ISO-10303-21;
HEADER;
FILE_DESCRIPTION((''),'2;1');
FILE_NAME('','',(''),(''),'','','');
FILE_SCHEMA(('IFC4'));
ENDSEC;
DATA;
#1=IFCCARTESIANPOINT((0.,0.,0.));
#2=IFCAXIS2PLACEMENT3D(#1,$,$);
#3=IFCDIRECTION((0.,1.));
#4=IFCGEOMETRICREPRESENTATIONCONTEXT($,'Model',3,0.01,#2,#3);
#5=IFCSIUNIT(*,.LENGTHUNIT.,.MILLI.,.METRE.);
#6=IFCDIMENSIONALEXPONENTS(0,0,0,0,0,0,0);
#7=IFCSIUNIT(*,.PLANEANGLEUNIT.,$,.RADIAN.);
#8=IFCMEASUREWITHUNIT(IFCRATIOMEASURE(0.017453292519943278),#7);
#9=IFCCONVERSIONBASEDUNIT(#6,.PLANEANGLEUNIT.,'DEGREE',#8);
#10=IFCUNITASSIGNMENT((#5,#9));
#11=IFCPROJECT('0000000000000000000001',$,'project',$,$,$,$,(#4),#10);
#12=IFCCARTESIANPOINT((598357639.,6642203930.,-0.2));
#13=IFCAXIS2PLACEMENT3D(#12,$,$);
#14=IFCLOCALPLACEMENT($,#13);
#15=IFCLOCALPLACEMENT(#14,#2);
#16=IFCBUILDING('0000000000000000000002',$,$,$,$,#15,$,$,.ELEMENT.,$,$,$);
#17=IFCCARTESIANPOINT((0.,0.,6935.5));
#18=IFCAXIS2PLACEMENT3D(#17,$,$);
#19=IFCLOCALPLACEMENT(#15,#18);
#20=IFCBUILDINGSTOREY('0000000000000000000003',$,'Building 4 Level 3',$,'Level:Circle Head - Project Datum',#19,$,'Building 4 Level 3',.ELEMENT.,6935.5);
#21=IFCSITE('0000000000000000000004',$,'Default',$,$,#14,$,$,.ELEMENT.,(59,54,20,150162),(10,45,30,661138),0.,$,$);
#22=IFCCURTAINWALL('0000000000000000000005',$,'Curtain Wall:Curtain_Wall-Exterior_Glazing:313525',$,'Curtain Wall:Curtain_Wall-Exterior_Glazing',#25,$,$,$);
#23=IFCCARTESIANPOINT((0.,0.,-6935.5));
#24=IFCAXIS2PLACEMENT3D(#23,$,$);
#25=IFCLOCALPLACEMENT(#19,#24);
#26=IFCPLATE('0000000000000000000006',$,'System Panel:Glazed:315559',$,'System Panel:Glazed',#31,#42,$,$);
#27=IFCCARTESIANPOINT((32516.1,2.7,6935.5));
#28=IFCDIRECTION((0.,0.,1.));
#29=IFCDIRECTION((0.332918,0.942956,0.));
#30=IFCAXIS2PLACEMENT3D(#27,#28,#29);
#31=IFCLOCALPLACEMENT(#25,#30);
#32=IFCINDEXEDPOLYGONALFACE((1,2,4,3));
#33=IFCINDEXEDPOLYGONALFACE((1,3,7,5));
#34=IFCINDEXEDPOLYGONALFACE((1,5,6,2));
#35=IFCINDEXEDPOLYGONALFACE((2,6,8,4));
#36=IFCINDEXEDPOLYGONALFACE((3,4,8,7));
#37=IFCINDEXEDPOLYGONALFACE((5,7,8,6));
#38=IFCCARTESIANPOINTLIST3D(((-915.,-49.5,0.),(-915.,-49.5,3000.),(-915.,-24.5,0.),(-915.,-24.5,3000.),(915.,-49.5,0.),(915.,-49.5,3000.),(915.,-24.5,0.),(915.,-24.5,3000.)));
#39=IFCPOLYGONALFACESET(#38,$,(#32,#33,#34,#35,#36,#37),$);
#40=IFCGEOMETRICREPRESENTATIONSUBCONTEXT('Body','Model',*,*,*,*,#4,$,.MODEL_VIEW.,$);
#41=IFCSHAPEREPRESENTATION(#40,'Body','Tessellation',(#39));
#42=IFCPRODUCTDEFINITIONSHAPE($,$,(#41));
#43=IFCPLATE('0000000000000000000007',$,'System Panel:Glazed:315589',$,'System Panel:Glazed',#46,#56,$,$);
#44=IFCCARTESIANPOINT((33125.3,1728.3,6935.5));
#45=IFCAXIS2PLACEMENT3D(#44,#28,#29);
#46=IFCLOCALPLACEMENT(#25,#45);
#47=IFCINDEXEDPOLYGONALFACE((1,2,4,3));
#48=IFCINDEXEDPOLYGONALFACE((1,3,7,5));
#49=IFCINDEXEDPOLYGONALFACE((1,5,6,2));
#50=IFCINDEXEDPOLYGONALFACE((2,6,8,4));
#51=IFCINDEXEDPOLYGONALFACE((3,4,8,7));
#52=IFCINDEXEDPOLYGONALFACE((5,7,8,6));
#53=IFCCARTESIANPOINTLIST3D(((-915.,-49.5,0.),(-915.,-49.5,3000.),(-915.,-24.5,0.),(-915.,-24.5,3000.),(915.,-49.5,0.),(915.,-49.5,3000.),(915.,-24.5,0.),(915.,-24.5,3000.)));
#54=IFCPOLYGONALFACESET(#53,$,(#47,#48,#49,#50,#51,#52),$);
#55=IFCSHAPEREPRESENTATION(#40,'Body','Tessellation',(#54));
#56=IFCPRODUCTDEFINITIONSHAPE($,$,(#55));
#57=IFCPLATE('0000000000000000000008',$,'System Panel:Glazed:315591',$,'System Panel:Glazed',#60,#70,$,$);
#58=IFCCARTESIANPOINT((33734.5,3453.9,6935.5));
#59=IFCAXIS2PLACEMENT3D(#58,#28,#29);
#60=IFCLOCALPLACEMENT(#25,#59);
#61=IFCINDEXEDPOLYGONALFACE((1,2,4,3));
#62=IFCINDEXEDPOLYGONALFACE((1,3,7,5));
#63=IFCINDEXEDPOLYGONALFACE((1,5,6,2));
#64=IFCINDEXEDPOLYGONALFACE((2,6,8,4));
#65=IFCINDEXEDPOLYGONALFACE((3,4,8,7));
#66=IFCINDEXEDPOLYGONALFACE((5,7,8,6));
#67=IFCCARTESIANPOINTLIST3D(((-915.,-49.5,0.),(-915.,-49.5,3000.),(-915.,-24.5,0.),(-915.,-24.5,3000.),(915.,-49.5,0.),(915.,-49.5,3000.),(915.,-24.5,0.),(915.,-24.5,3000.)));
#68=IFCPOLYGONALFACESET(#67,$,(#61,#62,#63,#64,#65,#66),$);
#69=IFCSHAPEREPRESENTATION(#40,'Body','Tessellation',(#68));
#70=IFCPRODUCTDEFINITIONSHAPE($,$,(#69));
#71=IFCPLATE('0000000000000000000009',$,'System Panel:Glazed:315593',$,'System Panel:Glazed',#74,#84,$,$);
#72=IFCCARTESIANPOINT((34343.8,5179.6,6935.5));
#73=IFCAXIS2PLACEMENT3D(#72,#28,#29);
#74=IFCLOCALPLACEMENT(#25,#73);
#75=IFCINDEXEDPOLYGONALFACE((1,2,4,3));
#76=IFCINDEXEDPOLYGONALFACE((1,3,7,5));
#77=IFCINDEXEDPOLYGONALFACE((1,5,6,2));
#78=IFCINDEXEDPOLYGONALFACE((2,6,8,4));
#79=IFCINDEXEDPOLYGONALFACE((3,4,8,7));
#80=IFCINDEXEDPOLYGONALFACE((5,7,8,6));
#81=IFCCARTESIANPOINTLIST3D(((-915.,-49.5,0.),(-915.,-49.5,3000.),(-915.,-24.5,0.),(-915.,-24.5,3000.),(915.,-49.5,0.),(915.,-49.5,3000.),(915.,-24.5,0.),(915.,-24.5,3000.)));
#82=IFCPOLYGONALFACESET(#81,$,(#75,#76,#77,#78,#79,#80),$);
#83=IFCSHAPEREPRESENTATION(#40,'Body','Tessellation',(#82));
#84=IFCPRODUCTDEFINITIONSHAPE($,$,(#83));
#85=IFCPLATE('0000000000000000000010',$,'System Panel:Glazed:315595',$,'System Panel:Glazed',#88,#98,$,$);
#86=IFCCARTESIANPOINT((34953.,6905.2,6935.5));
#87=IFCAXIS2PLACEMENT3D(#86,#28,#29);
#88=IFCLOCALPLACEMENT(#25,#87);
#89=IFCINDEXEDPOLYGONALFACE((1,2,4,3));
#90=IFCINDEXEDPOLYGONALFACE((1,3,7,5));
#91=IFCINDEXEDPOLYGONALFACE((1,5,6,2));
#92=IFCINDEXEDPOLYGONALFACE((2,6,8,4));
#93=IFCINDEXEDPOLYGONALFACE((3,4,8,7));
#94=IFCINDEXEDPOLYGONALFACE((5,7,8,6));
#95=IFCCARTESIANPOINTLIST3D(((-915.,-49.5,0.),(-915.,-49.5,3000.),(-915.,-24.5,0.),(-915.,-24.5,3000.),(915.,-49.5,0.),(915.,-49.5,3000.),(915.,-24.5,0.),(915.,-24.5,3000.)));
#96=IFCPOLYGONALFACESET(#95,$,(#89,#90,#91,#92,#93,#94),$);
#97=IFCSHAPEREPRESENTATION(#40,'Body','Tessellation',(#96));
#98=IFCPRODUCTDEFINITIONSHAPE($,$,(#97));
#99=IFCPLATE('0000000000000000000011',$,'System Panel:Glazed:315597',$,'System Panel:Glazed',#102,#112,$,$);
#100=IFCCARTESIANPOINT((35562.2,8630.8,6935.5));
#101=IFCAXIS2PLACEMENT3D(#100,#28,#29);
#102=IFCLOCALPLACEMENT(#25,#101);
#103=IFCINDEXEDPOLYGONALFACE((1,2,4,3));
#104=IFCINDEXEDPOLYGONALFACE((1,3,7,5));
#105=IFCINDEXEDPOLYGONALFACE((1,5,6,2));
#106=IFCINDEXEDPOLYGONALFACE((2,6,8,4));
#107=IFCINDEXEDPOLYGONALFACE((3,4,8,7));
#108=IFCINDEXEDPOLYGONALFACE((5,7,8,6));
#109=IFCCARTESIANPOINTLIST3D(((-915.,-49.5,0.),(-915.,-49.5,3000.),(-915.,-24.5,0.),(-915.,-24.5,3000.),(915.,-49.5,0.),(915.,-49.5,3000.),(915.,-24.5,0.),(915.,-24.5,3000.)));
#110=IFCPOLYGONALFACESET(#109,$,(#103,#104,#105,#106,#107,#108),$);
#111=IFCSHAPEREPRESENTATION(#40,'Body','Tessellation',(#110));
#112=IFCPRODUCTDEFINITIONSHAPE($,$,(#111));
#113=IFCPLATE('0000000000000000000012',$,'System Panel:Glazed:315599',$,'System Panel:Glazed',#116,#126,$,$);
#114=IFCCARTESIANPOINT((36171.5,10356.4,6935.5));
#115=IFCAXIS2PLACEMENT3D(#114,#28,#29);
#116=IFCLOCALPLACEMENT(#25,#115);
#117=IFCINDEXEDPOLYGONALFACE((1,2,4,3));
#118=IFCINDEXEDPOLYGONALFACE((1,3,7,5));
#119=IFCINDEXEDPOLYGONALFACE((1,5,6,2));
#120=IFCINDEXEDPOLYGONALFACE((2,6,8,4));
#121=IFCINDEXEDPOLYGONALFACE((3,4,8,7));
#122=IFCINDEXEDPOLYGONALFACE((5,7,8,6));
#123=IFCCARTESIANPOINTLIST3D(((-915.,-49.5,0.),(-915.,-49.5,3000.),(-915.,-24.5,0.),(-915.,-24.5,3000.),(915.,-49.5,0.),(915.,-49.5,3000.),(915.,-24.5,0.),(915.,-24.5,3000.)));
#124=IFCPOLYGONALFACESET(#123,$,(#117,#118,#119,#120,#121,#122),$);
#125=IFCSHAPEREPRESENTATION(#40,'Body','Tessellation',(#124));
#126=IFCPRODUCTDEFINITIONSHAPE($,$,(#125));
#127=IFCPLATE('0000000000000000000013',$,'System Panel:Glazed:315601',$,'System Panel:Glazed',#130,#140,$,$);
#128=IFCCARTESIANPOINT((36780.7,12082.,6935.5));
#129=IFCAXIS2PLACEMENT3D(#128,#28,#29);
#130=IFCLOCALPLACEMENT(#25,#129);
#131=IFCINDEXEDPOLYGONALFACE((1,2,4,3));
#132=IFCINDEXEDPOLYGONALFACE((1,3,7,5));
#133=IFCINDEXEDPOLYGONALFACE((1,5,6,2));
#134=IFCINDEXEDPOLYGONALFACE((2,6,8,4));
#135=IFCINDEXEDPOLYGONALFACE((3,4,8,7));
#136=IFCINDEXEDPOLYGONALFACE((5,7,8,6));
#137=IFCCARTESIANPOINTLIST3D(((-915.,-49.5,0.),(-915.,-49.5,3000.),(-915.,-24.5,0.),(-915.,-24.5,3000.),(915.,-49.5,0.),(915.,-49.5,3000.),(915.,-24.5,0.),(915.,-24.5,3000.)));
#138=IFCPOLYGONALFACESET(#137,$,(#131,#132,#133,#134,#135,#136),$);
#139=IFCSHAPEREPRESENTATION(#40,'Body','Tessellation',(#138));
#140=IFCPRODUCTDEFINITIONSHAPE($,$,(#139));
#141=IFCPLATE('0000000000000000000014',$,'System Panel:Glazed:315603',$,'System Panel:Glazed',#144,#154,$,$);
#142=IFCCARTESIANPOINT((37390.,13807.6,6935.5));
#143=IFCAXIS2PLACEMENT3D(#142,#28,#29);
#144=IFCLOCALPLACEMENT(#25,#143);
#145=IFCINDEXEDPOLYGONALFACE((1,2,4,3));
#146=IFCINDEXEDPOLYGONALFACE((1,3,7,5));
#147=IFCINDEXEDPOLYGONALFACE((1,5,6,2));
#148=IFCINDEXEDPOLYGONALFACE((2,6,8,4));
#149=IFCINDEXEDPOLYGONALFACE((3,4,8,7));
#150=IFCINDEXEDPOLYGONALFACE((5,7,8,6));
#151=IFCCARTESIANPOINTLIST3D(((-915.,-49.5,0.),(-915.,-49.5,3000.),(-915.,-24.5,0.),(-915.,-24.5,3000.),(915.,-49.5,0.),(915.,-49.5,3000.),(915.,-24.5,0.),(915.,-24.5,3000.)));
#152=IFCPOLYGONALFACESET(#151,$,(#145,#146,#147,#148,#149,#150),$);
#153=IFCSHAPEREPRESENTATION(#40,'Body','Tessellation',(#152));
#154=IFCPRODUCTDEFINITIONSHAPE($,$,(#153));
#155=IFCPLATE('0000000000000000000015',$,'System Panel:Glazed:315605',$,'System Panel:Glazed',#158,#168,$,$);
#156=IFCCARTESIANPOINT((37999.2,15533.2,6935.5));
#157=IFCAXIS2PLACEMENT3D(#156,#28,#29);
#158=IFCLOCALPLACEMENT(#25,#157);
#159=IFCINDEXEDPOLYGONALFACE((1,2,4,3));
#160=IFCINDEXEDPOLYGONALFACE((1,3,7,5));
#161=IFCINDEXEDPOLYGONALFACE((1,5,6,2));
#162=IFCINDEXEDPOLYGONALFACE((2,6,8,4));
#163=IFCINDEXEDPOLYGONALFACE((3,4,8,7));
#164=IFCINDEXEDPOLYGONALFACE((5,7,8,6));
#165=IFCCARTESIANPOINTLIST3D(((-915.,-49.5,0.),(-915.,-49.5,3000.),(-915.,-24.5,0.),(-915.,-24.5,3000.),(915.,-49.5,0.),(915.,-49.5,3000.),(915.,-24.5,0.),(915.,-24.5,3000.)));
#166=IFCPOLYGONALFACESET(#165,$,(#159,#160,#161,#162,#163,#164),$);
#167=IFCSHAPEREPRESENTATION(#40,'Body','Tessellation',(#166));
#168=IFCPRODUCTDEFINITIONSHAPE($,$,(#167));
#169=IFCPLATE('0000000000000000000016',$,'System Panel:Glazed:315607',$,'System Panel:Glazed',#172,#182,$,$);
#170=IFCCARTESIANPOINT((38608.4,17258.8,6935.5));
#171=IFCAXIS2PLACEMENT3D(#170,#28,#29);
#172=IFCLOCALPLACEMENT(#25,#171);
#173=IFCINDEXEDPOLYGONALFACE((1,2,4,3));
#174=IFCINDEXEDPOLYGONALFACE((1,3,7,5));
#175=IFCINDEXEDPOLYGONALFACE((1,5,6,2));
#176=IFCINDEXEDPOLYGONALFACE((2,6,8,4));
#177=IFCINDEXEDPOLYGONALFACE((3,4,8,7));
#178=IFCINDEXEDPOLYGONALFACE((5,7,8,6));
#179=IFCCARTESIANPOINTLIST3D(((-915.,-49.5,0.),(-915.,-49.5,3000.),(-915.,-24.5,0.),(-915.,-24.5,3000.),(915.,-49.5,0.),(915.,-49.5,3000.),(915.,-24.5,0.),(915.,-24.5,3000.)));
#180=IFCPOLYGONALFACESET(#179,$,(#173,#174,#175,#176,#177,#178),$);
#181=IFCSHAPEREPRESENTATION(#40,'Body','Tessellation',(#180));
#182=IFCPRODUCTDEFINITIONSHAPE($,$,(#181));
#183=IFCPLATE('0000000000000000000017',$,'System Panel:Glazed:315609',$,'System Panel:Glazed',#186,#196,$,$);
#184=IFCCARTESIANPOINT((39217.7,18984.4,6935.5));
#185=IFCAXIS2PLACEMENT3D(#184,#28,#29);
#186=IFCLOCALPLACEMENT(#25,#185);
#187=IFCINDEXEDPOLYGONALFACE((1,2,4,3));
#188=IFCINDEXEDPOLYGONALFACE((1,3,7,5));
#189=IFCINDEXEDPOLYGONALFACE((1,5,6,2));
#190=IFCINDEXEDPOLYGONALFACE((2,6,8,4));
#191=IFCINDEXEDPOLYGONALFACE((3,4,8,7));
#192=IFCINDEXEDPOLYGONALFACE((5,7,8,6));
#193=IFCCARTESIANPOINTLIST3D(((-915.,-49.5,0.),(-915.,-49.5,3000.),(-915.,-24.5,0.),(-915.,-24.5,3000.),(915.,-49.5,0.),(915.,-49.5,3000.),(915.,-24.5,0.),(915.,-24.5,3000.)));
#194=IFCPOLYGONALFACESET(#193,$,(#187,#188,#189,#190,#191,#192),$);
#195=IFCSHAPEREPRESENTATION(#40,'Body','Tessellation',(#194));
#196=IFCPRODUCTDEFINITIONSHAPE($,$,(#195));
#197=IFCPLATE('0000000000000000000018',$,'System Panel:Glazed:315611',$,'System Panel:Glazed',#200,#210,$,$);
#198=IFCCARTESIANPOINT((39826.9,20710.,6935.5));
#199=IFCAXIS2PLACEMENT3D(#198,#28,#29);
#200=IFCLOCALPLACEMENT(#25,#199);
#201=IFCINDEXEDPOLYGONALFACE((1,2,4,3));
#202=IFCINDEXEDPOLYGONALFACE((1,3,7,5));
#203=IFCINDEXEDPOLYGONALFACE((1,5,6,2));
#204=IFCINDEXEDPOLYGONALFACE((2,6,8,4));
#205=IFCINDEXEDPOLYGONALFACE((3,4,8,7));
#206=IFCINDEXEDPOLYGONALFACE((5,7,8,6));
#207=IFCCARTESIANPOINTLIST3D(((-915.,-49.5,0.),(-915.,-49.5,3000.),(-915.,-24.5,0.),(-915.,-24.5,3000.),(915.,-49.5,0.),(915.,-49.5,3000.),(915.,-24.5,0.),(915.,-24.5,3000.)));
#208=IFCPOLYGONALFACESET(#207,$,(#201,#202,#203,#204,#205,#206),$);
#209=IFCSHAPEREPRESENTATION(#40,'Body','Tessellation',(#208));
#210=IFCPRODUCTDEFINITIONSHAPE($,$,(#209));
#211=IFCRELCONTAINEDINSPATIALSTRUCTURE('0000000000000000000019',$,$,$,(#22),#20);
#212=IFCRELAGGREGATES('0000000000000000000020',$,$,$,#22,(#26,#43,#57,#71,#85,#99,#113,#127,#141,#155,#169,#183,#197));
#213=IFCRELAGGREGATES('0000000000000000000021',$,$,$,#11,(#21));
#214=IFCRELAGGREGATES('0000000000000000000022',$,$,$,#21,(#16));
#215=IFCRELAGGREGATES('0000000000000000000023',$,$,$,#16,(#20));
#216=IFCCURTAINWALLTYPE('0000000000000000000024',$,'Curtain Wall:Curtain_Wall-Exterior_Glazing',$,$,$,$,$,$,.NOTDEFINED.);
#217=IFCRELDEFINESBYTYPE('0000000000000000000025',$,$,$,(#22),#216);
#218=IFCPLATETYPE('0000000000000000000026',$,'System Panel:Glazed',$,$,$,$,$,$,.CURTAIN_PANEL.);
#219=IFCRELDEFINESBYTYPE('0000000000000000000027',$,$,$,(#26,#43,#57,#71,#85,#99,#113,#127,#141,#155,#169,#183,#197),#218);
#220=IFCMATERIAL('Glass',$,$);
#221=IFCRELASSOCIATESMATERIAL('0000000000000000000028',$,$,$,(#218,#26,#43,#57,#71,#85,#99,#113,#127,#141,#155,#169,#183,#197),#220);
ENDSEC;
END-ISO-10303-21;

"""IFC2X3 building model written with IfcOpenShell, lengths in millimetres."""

from ifc_helpers import new_model, entity, si_unit, converted_unit, direction, frame, frame_2d, origin, place, context, subcontext, project, spatial, rectangle, extrude, source, transform, mapped, material, type_object, type_shapes, element, aggregate, save


model = new_model("IFC2X3")

# Units and contexts
model_context = context("Model", 3, precision=0.01, world=origin(), true_north=direction((0.0, 1.0)))
body_context = subcontext(model_context, "Body", "Model", "MODEL_VIEW")
ifc_project = project(units=[si_unit("LENGTHUNIT", "METRE", prefix="MILLI"), converted_unit("PLANEANGLEUNIT", "DEGREE", entity("IfcRatioMeasure", 0.017453292519943278), si_unit("PLANEANGLEUNIT", "RADIAN"), dimensions=[0, 0, 0, 0, 0, 0, 0])], contexts=[model_context])

# Site, building, storey
site_placement = place(None, frame((598357639.0, 6642203930.0, -0.2)))
site = spatial("IfcSite", under=ifc_project, at=site_placement, Name="Default", CompositionType="ELEMENT", RefLatitude=(59, 54, 20, 150162), RefLongitude=(10, 45, 30, 661138), RefElevation=0.0)
building_placement = place(site_placement, origin())
building = spatial("IfcBuilding", under=site, at=building_placement, CompositionType="ELEMENT")
storey_placement = place(building_placement, frame((0.0, 0.0, 6935.5)))
storey = spatial("IfcBuildingStorey", under=building, at=storey_placement, Name="Building 4 Level 3", ObjectType="Level:Circle Head - Project Datum", LongName="Building 4 Level 3", CompositionType="ELEMENT", Elevation=6935.5)

# Curtain wall, plates
curtain_wall_type = type_object("IfcCurtainWallType", Name="Curtain Wall:Curtain_Wall-Exterior_Glazing", PredefinedType="NOTDEFINED")
curtain_wall_placement = place(storey_placement, frame((0.0, 0.0, -6935.5)))
curtain_wall = element("IfcCurtainWall", 1, at=curtain_wall_placement, inside=storey, type_object=curtain_wall_type, Name="Curtain Wall:Curtain_Wall-Exterior_Glazing:313525", ObjectType="Curtain Wall:Curtain_Wall-Exterior_Glazing")
ifc_material_1 = material(Name="Glass")
plate_type_1 = type_object("IfcPlateType", Name="System Panel:Glazed", PredefinedType="CURTAIN_PANEL", material=ifc_material_1)
shared_shape_1 = source(origin(), body_context, "Body", "SweptSolid", [
    extrude(rectangle(XDim=25.0, YDim=1830.0, at=frame_2d((0.0, 0.0), x_axis=(1.0, 0.0))), frame((0.0, -37.0, 0.0), z_axis=(0.0, 0.0, 1.0), x_axis=(0.0, 1.0, 0.0)), (0.0, 0.0, 1.0), 3000.0),
])
type_shapes(plate_type_1, [shared_shape_1])
plate_1_placement = place(curtain_wall_placement, frame((32516.1, 2.7, 6935.5), z_axis=(0.0, 0.0, 1.0), x_axis=(0.332918, 0.942956, 0.0)))
plate_1 = element("IfcPlate", 2, at=plate_1_placement, type_object=plate_type_1, material=ifc_material_1, Name="System Panel:Glazed:315559", ObjectType="System Panel:Glazed", context=body_context, shape_type="MappedRepresentation", body=[
    mapped(shared_shape_1, transform((0.0, 0.0, 0.0), scale=1.0)),
])
plate_2_placement = place(curtain_wall_placement, frame((33125.3, 1728.3, 6935.5), z_axis=(0.0, 0.0, 1.0), x_axis=(0.332918, 0.942956, 0.0)))
plate_2 = element("IfcPlate", 3, at=plate_2_placement, type_object=plate_type_1, material=ifc_material_1, Name="System Panel:Glazed:315589", ObjectType="System Panel:Glazed", context=body_context, shape_type="MappedRepresentation", body=[
    mapped(shared_shape_1, transform((0.0, 0.0, 0.0), scale=1.0)),
])
plate_3_placement = place(curtain_wall_placement, frame((33734.5, 3453.9, 6935.5), z_axis=(0.0, 0.0, 1.0), x_axis=(0.332918, 0.942956, 0.0)))
plate_3 = element("IfcPlate", 4, at=plate_3_placement, type_object=plate_type_1, material=ifc_material_1, Name="System Panel:Glazed:315591", ObjectType="System Panel:Glazed", context=body_context, shape_type="MappedRepresentation", body=[
    mapped(shared_shape_1, transform((0.0, 0.0, 0.0), scale=1.0)),
])
plate_4_placement = place(curtain_wall_placement, frame((34343.8, 5179.6, 6935.5), z_axis=(0.0, 0.0, 1.0), x_axis=(0.332918, 0.942956, 0.0)))
plate_4 = element("IfcPlate", 5, at=plate_4_placement, type_object=plate_type_1, material=ifc_material_1, Name="System Panel:Glazed:315593", ObjectType="System Panel:Glazed", context=body_context, shape_type="MappedRepresentation", body=[
    mapped(shared_shape_1, transform((0.0, 0.0, 0.0), scale=1.0)),
])
plate_5_placement = place(curtain_wall_placement, frame((34953.0, 6905.2, 6935.5), z_axis=(0.0, 0.0, 1.0), x_axis=(0.332918, 0.942956, 0.0)))
plate_5 = element("IfcPlate", 6, at=plate_5_placement, type_object=plate_type_1, material=ifc_material_1, Name="System Panel:Glazed:315595", ObjectType="System Panel:Glazed", context=body_context, shape_type="MappedRepresentation", body=[
    mapped(shared_shape_1, transform((0.0, 0.0, 0.0), scale=1.0)),
])
plate_6_placement = place(curtain_wall_placement, frame((35562.2, 8630.8, 6935.5), z_axis=(0.0, 0.0, 1.0), x_axis=(0.332918, 0.942956, 0.0)))
plate_6 = element("IfcPlate", 7, at=plate_6_placement, type_object=plate_type_1, material=ifc_material_1, Name="System Panel:Glazed:315597", ObjectType="System Panel:Glazed", context=body_context, shape_type="MappedRepresentation", body=[
    mapped(shared_shape_1, transform((0.0, 0.0, 0.0), scale=1.0)),
])
plate_7_placement = place(curtain_wall_placement, frame((36171.5, 10356.4, 6935.5), z_axis=(0.0, 0.0, 1.0), x_axis=(0.332918, 0.942956, 0.0)))
plate_7 = element("IfcPlate", 8, at=plate_7_placement, type_object=plate_type_1, material=ifc_material_1, Name="System Panel:Glazed:315599", ObjectType="System Panel:Glazed", context=body_context, shape_type="MappedRepresentation", body=[
    mapped(shared_shape_1, transform((0.0, 0.0, 0.0), scale=1.0)),
])
plate_8_placement = place(curtain_wall_placement, frame((36780.7, 12082.0, 6935.5), z_axis=(0.0, 0.0, 1.0), x_axis=(0.332918, 0.942956, 0.0)))
plate_8 = element("IfcPlate", 9, at=plate_8_placement, type_object=plate_type_1, material=ifc_material_1, Name="System Panel:Glazed:315601", ObjectType="System Panel:Glazed", context=body_context, shape_type="MappedRepresentation", body=[
    mapped(shared_shape_1, transform((0.0, 0.0, 0.0), scale=1.0)),
])
plate_9_placement = place(curtain_wall_placement, frame((37390.0, 13807.6, 6935.5), z_axis=(0.0, 0.0, 1.0), x_axis=(0.332918, 0.942956, 0.0)))
plate_9 = element("IfcPlate", 10, at=plate_9_placement, type_object=plate_type_1, material=ifc_material_1, Name="System Panel:Glazed:315603", ObjectType="System Panel:Glazed", context=body_context, shape_type="MappedRepresentation", body=[
    mapped(shared_shape_1, transform((0.0, 0.0, 0.0), scale=1.0)),
])
plate_10_placement = place(curtain_wall_placement, frame((37999.2, 15533.2, 6935.5), z_axis=(0.0, 0.0, 1.0), x_axis=(0.332918, 0.942956, 0.0)))
plate_10 = element("IfcPlate", 11, at=plate_10_placement, type_object=plate_type_1, material=ifc_material_1, Name="System Panel:Glazed:315605", ObjectType="System Panel:Glazed", context=body_context, shape_type="MappedRepresentation", body=[
    mapped(shared_shape_1, transform((0.0, 0.0, 0.0), scale=1.0)),
])
plate_11_placement = place(curtain_wall_placement, frame((38608.4, 17258.8, 6935.5), z_axis=(0.0, 0.0, 1.0), x_axis=(0.332918, 0.942956, 0.0)))
plate_11 = element("IfcPlate", 12, at=plate_11_placement, type_object=plate_type_1, material=ifc_material_1, Name="System Panel:Glazed:315607", ObjectType="System Panel:Glazed", context=body_context, shape_type="MappedRepresentation", body=[
    mapped(shared_shape_1, transform((0.0, 0.0, 0.0), scale=1.0)),
])
plate_12_placement = place(curtain_wall_placement, frame((39217.7, 18984.4, 6935.5), z_axis=(0.0, 0.0, 1.0), x_axis=(0.332918, 0.942956, 0.0)))
plate_12 = element("IfcPlate", 13, at=plate_12_placement, type_object=plate_type_1, material=ifc_material_1, Name="System Panel:Glazed:315609", ObjectType="System Panel:Glazed", context=body_context, shape_type="MappedRepresentation", body=[
    mapped(shared_shape_1, transform((0.0, 0.0, 0.0), scale=1.0)),
])
plate_13_placement = place(curtain_wall_placement, frame((39826.9, 20710.0, 6935.5), z_axis=(0.0, 0.0, 1.0), x_axis=(0.332918, 0.942956, 0.0)))
plate_13 = element("IfcPlate", 14, at=plate_13_placement, type_object=plate_type_1, material=ifc_material_1, Name="System Panel:Glazed:315611", ObjectType="System Panel:Glazed", context=body_context, shape_type="MappedRepresentation", body=[
    mapped(shared_shape_1, transform((0.0, 0.0, 0.0), scale=1.0)),
])
aggregate(curtain_wall, [plate_1, plate_2, plate_3, plate_4, plate_5, plate_6, plate_7, plate_8, plate_9, plate_10, plate_11, plate_12, plate_13])

save(model, "model.ifc")
